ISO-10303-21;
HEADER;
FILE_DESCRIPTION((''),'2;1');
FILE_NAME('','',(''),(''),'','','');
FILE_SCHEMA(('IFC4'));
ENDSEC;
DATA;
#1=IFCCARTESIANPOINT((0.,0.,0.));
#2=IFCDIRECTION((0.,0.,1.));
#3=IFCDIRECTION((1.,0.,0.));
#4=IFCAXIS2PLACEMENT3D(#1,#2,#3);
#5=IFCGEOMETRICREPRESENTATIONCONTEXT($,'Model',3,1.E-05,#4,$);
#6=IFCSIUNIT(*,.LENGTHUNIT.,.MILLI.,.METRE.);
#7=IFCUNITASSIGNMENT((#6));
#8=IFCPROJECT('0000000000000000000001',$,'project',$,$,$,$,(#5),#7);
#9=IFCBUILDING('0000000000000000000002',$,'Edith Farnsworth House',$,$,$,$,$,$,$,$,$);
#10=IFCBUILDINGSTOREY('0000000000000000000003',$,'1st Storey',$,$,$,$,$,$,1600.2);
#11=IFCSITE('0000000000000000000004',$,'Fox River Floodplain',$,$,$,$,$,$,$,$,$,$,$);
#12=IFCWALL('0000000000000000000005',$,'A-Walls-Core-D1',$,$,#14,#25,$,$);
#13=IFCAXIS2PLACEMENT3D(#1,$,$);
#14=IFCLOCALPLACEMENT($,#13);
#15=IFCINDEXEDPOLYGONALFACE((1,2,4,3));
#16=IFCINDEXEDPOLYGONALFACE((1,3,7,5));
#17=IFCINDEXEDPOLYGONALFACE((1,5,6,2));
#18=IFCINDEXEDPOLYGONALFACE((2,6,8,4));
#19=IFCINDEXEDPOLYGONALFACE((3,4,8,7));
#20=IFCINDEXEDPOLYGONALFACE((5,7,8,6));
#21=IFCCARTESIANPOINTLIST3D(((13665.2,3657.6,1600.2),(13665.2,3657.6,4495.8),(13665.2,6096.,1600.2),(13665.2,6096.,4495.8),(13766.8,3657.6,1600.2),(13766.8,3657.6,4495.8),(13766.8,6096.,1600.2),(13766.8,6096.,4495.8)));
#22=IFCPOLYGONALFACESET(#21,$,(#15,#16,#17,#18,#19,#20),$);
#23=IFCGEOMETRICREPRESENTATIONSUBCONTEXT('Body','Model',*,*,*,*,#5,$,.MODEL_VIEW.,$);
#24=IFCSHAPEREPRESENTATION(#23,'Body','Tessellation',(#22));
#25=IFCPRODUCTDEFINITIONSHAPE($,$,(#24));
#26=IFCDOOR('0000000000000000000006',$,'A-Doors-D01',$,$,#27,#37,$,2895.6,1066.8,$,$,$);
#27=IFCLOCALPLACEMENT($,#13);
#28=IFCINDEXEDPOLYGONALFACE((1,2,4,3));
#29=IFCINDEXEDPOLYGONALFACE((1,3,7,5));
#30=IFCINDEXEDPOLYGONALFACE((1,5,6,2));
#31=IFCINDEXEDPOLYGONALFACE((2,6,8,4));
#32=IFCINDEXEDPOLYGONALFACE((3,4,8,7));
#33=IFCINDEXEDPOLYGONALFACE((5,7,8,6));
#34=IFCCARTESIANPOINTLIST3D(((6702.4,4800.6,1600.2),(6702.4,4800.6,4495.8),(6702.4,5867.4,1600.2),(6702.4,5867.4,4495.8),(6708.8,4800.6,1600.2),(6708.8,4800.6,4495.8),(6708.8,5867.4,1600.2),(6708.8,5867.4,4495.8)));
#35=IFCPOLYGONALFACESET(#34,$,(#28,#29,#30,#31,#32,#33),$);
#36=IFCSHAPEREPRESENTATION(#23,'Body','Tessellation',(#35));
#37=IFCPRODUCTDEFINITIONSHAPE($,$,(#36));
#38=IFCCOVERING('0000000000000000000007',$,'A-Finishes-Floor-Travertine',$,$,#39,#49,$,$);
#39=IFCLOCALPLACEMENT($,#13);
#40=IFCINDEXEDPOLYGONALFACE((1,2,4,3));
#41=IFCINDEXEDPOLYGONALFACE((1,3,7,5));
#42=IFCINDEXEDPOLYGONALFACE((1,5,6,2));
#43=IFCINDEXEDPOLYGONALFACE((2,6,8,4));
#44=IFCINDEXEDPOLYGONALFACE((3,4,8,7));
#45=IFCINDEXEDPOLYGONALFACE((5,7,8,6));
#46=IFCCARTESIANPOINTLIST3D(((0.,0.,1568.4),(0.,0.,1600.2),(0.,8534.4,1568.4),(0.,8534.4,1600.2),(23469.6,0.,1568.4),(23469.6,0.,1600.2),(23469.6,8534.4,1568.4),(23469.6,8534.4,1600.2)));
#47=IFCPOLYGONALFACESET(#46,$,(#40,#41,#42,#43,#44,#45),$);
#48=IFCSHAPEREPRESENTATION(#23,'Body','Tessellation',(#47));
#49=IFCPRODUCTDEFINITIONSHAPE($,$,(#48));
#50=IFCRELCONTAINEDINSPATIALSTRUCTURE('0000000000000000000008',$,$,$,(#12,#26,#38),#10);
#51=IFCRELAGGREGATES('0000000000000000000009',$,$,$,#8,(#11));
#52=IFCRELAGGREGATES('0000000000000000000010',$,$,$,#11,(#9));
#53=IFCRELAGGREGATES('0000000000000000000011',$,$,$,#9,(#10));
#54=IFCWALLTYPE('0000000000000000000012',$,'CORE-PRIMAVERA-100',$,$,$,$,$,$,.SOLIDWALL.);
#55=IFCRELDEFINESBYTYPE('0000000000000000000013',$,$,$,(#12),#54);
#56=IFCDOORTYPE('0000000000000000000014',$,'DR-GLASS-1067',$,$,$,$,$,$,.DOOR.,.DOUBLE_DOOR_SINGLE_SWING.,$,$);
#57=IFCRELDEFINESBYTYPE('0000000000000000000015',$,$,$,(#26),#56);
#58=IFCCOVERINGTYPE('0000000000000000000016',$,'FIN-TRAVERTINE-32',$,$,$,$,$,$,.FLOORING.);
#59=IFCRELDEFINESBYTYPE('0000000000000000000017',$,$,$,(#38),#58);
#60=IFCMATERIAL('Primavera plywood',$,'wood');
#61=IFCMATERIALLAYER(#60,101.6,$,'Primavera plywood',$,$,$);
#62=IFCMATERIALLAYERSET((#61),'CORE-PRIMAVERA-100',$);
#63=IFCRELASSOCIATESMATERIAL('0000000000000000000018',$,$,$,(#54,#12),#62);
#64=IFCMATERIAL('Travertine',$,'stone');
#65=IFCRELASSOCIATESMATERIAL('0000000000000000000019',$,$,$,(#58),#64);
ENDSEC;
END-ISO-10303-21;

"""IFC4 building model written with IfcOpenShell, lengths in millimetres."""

from ifc_helpers import new_model, si_unit, frame, origin, origin_with_axes, place, context, subcontext, project, spatial, indexed_curve, rectangle, outline, extrude, material, layer, layer_set, layer_usage, type_object, element, save


model = new_model("IFC4")

# Units and contexts
model_context = context("Model", 3, precision=1e-05, world=origin_with_axes())
body_context = subcontext(model_context, "Body", "Model", "MODEL_VIEW")
ifc_project = project(units=[si_unit("LENGTHUNIT", "METRE", prefix="MILLI")], contexts=[model_context])

# Site, building, storey
site = spatial("IfcSite", under=ifc_project, Name="Fox River Floodplain")
building = spatial("IfcBuilding", under=site, Name="Edith Farnsworth House")
storey = spatial("IfcBuildingStorey", under=building, Name="1st Storey", Elevation=1600.2)

# Shared definitions
ifc_material_1 = material(Name="Travertine", Category="stone")

# Wall
ifc_material_2 = material(Name="Primavera plywood", Category="wood")
ifc_layer_1 = layer(ifc_material_2, 101.6, Name="Primavera plywood")
ifc_layer_set_1 = layer_set([ifc_layer_1], Name="CORE-PRIMAVERA-100")
wall_type = type_object("IfcWallType", Name="CORE-PRIMAVERA-100", PredefinedType="SOLIDWALL", material=ifc_layer_set_1)
ifc_layer_usage_1 = layer_usage(ifc_layer_set_1, "AXIS2", "POSITIVE", 0.0)
wall_1_placement = place(None, frame((13716.0, 4876.8, 1600.2), z_axis=(0.0, 0.0, 1.0), x_axis=(0.0, 1.0, 0.0)))
element("IfcWall", 1, at=wall_1_placement, inside=storey, type_object=wall_type, material=ifc_layer_usage_1, Name="A-Walls-Core-D1", context=body_context, shape_type="SweptSolid", body=[
    extrude(rectangle(XDim=2438.4, YDim=101.6), origin(), (0.0, 0.0, 1.0), 2895.6),
])

# Door
door_type = type_object("IfcDoorType", Name="DR-GLASS-1067", OperationType="DOUBLE_DOOR_SINGLE_SWING", PredefinedType="DOOR")
door_placement = place(None, frame((6705.6, 5334.0, 1600.2), z_axis=(0.0, 0.0, 1.0), x_axis=(0.0, 1.0, 0.0)))
element("IfcDoor", 2, at=door_placement, inside=storey, type_object=door_type, Name="A-Doors-D01", OverallHeight=2895.6, OverallWidth=1066.8, context=body_context, shape_type="SweptSolid", body=[
    extrude(rectangle(XDim=1066.8, YDim=6.3), origin(), (0.0, 0.0, 1.0), 2895.6),
])

# Covering
covering_type = type_object("IfcCoveringType", Name="FIN-TRAVERTINE-32", PredefinedType="FLOORING", material=ifc_material_1)
covering_placement = place(None, frame((0.0, 0.0, 1568.5), z_axis=(0.0, 0.0, 1.0), x_axis=(1.0, 0.0, 0.0)))
element("IfcCovering", 3, at=covering_placement, inside=storey, type_object=covering_type, Name="A-Finishes-Floor-Travertine", context=body_context, shape_type="SweptSolid", body=[
    extrude(outline(indexed_curve([(0.0, 0.0), (23469.6, 0.0), (23469.6, 8534.4), (0.0, 8534.4)])), None, (0.0, 0.0, 1.0), 31.8),
])

save(model, "model.ifc")
